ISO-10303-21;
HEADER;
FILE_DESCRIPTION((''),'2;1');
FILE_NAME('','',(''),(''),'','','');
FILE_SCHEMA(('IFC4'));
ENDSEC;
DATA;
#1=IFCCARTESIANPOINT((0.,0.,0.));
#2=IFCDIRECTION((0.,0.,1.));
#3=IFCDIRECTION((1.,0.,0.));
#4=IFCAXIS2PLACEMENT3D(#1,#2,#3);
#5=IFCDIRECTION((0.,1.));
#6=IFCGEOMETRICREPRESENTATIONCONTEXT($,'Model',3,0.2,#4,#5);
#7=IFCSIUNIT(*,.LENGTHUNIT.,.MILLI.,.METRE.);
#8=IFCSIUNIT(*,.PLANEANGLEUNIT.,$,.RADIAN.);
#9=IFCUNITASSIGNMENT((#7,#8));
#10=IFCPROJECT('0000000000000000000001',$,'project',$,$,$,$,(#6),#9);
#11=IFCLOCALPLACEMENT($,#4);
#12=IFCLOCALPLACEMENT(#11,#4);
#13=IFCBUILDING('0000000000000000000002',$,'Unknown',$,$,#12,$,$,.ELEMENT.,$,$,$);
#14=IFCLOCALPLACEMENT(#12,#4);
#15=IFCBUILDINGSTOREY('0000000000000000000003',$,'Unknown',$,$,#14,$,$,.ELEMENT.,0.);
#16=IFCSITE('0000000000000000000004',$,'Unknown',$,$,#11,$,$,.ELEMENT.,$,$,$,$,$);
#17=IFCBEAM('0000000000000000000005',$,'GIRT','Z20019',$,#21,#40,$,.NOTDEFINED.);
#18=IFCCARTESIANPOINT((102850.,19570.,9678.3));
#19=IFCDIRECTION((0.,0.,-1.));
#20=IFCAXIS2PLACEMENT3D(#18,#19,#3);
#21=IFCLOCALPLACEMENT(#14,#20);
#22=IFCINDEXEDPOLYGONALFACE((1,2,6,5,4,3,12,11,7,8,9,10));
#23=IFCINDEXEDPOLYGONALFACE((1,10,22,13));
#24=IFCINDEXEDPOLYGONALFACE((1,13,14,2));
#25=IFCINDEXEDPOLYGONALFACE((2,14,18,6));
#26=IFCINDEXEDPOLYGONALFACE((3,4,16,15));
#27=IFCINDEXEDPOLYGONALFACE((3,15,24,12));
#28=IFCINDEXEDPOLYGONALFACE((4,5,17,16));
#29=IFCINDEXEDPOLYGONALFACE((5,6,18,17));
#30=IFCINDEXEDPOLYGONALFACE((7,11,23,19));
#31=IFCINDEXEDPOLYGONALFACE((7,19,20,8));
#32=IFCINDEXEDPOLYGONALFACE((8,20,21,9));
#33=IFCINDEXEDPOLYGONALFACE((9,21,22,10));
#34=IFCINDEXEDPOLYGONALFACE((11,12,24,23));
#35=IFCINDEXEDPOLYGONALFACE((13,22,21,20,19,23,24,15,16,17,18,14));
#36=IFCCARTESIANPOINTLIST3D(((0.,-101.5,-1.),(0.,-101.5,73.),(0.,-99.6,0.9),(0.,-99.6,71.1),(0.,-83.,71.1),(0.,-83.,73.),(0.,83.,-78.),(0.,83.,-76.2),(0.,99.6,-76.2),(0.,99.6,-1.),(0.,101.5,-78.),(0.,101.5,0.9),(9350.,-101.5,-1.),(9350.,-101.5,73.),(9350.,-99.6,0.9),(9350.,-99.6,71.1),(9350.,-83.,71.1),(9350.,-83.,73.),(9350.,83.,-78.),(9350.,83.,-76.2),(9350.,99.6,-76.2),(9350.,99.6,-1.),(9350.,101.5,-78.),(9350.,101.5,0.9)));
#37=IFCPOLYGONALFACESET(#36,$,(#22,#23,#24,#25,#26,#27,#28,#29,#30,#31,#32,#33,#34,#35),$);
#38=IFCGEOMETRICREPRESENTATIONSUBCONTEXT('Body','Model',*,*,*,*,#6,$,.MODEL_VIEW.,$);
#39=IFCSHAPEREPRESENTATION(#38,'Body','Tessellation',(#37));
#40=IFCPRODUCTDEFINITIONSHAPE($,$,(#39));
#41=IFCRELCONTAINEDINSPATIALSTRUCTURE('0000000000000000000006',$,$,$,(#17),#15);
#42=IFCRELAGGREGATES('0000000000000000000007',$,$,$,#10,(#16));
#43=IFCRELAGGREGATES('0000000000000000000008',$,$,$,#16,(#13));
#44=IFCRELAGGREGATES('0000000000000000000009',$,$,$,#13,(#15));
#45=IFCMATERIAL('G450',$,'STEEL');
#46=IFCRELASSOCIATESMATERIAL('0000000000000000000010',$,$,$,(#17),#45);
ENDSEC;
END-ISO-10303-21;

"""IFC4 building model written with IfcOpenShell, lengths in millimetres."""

from ifc_helpers import new_model, si_unit, direction, frame, origin_with_axes, place, context, subcontext, project, spatial, line, indexed_curve, outline, extrude, material, element, save


model = new_model("IFC4")

# Units and contexts
model_context = context("Model", 3, precision=0.2, world=origin_with_axes(), true_north=direction((0.0, 1.0)))
body_context = subcontext(model_context, "Body", "Model", "MODEL_VIEW")
ifc_project = project(units=[si_unit("LENGTHUNIT", "METRE", prefix="MILLI"), si_unit("PLANEANGLEUNIT", "RADIAN")], contexts=[model_context])

# Site, building, storey
site_placement = place(None, origin_with_axes())
site = spatial("IfcSite", under=ifc_project, at=site_placement, Name="Unknown", CompositionType="ELEMENT")
building_placement = place(site_placement, origin_with_axes())
building = spatial("IfcBuilding", under=site, at=building_placement, Name="Unknown", CompositionType="ELEMENT")
storey_placement = place(building_placement, origin_with_axes())
storey = spatial("IfcBuildingStorey", under=building, at=storey_placement, Name="Unknown", CompositionType="ELEMENT", Elevation=0.0)

# Beam
ifc_material_1 = material(Name="G450", Category="STEEL")
beam_1_placement = place(storey_placement, frame((102850.0, 19570.0, 9678.3), z_axis=(0.0, 0.0, -1.0), x_axis=(1.0, 0.0, 0.0)))
element("IfcBeam", 1, at=beam_1_placement, inside=storey, material=ifc_material_1, Name="GIRT", Description="Z20019", PredefinedType="NOTDEFINED", context=body_context, shape_type="SolidModel", body=[
    extrude(outline(indexed_curve([(73.0, -101.5), (73.0, -83.0), (71.2, -83.0), (71.2, -99.6), (0.9, -99.6), (0.9, 101.5), (-78.0, 101.5), (-78.0, 83.0), (-76.2, 83.0), (-76.2, 99.6), (-0.9, 99.6), (-0.9, -101.5)], segments=[line(1, 2, 3, 4, 5, 6, 7, 8, 9, 10, 11, 12, 1)])), frame((0.0, 0.0, 0.0), z_axis=(-1.0, 0.0, 0.0), x_axis=(0.0, 0.0, 1.0)), (0.0, 0.0, -1.0), 9350.0),
])

save(model, "model.ifc")
